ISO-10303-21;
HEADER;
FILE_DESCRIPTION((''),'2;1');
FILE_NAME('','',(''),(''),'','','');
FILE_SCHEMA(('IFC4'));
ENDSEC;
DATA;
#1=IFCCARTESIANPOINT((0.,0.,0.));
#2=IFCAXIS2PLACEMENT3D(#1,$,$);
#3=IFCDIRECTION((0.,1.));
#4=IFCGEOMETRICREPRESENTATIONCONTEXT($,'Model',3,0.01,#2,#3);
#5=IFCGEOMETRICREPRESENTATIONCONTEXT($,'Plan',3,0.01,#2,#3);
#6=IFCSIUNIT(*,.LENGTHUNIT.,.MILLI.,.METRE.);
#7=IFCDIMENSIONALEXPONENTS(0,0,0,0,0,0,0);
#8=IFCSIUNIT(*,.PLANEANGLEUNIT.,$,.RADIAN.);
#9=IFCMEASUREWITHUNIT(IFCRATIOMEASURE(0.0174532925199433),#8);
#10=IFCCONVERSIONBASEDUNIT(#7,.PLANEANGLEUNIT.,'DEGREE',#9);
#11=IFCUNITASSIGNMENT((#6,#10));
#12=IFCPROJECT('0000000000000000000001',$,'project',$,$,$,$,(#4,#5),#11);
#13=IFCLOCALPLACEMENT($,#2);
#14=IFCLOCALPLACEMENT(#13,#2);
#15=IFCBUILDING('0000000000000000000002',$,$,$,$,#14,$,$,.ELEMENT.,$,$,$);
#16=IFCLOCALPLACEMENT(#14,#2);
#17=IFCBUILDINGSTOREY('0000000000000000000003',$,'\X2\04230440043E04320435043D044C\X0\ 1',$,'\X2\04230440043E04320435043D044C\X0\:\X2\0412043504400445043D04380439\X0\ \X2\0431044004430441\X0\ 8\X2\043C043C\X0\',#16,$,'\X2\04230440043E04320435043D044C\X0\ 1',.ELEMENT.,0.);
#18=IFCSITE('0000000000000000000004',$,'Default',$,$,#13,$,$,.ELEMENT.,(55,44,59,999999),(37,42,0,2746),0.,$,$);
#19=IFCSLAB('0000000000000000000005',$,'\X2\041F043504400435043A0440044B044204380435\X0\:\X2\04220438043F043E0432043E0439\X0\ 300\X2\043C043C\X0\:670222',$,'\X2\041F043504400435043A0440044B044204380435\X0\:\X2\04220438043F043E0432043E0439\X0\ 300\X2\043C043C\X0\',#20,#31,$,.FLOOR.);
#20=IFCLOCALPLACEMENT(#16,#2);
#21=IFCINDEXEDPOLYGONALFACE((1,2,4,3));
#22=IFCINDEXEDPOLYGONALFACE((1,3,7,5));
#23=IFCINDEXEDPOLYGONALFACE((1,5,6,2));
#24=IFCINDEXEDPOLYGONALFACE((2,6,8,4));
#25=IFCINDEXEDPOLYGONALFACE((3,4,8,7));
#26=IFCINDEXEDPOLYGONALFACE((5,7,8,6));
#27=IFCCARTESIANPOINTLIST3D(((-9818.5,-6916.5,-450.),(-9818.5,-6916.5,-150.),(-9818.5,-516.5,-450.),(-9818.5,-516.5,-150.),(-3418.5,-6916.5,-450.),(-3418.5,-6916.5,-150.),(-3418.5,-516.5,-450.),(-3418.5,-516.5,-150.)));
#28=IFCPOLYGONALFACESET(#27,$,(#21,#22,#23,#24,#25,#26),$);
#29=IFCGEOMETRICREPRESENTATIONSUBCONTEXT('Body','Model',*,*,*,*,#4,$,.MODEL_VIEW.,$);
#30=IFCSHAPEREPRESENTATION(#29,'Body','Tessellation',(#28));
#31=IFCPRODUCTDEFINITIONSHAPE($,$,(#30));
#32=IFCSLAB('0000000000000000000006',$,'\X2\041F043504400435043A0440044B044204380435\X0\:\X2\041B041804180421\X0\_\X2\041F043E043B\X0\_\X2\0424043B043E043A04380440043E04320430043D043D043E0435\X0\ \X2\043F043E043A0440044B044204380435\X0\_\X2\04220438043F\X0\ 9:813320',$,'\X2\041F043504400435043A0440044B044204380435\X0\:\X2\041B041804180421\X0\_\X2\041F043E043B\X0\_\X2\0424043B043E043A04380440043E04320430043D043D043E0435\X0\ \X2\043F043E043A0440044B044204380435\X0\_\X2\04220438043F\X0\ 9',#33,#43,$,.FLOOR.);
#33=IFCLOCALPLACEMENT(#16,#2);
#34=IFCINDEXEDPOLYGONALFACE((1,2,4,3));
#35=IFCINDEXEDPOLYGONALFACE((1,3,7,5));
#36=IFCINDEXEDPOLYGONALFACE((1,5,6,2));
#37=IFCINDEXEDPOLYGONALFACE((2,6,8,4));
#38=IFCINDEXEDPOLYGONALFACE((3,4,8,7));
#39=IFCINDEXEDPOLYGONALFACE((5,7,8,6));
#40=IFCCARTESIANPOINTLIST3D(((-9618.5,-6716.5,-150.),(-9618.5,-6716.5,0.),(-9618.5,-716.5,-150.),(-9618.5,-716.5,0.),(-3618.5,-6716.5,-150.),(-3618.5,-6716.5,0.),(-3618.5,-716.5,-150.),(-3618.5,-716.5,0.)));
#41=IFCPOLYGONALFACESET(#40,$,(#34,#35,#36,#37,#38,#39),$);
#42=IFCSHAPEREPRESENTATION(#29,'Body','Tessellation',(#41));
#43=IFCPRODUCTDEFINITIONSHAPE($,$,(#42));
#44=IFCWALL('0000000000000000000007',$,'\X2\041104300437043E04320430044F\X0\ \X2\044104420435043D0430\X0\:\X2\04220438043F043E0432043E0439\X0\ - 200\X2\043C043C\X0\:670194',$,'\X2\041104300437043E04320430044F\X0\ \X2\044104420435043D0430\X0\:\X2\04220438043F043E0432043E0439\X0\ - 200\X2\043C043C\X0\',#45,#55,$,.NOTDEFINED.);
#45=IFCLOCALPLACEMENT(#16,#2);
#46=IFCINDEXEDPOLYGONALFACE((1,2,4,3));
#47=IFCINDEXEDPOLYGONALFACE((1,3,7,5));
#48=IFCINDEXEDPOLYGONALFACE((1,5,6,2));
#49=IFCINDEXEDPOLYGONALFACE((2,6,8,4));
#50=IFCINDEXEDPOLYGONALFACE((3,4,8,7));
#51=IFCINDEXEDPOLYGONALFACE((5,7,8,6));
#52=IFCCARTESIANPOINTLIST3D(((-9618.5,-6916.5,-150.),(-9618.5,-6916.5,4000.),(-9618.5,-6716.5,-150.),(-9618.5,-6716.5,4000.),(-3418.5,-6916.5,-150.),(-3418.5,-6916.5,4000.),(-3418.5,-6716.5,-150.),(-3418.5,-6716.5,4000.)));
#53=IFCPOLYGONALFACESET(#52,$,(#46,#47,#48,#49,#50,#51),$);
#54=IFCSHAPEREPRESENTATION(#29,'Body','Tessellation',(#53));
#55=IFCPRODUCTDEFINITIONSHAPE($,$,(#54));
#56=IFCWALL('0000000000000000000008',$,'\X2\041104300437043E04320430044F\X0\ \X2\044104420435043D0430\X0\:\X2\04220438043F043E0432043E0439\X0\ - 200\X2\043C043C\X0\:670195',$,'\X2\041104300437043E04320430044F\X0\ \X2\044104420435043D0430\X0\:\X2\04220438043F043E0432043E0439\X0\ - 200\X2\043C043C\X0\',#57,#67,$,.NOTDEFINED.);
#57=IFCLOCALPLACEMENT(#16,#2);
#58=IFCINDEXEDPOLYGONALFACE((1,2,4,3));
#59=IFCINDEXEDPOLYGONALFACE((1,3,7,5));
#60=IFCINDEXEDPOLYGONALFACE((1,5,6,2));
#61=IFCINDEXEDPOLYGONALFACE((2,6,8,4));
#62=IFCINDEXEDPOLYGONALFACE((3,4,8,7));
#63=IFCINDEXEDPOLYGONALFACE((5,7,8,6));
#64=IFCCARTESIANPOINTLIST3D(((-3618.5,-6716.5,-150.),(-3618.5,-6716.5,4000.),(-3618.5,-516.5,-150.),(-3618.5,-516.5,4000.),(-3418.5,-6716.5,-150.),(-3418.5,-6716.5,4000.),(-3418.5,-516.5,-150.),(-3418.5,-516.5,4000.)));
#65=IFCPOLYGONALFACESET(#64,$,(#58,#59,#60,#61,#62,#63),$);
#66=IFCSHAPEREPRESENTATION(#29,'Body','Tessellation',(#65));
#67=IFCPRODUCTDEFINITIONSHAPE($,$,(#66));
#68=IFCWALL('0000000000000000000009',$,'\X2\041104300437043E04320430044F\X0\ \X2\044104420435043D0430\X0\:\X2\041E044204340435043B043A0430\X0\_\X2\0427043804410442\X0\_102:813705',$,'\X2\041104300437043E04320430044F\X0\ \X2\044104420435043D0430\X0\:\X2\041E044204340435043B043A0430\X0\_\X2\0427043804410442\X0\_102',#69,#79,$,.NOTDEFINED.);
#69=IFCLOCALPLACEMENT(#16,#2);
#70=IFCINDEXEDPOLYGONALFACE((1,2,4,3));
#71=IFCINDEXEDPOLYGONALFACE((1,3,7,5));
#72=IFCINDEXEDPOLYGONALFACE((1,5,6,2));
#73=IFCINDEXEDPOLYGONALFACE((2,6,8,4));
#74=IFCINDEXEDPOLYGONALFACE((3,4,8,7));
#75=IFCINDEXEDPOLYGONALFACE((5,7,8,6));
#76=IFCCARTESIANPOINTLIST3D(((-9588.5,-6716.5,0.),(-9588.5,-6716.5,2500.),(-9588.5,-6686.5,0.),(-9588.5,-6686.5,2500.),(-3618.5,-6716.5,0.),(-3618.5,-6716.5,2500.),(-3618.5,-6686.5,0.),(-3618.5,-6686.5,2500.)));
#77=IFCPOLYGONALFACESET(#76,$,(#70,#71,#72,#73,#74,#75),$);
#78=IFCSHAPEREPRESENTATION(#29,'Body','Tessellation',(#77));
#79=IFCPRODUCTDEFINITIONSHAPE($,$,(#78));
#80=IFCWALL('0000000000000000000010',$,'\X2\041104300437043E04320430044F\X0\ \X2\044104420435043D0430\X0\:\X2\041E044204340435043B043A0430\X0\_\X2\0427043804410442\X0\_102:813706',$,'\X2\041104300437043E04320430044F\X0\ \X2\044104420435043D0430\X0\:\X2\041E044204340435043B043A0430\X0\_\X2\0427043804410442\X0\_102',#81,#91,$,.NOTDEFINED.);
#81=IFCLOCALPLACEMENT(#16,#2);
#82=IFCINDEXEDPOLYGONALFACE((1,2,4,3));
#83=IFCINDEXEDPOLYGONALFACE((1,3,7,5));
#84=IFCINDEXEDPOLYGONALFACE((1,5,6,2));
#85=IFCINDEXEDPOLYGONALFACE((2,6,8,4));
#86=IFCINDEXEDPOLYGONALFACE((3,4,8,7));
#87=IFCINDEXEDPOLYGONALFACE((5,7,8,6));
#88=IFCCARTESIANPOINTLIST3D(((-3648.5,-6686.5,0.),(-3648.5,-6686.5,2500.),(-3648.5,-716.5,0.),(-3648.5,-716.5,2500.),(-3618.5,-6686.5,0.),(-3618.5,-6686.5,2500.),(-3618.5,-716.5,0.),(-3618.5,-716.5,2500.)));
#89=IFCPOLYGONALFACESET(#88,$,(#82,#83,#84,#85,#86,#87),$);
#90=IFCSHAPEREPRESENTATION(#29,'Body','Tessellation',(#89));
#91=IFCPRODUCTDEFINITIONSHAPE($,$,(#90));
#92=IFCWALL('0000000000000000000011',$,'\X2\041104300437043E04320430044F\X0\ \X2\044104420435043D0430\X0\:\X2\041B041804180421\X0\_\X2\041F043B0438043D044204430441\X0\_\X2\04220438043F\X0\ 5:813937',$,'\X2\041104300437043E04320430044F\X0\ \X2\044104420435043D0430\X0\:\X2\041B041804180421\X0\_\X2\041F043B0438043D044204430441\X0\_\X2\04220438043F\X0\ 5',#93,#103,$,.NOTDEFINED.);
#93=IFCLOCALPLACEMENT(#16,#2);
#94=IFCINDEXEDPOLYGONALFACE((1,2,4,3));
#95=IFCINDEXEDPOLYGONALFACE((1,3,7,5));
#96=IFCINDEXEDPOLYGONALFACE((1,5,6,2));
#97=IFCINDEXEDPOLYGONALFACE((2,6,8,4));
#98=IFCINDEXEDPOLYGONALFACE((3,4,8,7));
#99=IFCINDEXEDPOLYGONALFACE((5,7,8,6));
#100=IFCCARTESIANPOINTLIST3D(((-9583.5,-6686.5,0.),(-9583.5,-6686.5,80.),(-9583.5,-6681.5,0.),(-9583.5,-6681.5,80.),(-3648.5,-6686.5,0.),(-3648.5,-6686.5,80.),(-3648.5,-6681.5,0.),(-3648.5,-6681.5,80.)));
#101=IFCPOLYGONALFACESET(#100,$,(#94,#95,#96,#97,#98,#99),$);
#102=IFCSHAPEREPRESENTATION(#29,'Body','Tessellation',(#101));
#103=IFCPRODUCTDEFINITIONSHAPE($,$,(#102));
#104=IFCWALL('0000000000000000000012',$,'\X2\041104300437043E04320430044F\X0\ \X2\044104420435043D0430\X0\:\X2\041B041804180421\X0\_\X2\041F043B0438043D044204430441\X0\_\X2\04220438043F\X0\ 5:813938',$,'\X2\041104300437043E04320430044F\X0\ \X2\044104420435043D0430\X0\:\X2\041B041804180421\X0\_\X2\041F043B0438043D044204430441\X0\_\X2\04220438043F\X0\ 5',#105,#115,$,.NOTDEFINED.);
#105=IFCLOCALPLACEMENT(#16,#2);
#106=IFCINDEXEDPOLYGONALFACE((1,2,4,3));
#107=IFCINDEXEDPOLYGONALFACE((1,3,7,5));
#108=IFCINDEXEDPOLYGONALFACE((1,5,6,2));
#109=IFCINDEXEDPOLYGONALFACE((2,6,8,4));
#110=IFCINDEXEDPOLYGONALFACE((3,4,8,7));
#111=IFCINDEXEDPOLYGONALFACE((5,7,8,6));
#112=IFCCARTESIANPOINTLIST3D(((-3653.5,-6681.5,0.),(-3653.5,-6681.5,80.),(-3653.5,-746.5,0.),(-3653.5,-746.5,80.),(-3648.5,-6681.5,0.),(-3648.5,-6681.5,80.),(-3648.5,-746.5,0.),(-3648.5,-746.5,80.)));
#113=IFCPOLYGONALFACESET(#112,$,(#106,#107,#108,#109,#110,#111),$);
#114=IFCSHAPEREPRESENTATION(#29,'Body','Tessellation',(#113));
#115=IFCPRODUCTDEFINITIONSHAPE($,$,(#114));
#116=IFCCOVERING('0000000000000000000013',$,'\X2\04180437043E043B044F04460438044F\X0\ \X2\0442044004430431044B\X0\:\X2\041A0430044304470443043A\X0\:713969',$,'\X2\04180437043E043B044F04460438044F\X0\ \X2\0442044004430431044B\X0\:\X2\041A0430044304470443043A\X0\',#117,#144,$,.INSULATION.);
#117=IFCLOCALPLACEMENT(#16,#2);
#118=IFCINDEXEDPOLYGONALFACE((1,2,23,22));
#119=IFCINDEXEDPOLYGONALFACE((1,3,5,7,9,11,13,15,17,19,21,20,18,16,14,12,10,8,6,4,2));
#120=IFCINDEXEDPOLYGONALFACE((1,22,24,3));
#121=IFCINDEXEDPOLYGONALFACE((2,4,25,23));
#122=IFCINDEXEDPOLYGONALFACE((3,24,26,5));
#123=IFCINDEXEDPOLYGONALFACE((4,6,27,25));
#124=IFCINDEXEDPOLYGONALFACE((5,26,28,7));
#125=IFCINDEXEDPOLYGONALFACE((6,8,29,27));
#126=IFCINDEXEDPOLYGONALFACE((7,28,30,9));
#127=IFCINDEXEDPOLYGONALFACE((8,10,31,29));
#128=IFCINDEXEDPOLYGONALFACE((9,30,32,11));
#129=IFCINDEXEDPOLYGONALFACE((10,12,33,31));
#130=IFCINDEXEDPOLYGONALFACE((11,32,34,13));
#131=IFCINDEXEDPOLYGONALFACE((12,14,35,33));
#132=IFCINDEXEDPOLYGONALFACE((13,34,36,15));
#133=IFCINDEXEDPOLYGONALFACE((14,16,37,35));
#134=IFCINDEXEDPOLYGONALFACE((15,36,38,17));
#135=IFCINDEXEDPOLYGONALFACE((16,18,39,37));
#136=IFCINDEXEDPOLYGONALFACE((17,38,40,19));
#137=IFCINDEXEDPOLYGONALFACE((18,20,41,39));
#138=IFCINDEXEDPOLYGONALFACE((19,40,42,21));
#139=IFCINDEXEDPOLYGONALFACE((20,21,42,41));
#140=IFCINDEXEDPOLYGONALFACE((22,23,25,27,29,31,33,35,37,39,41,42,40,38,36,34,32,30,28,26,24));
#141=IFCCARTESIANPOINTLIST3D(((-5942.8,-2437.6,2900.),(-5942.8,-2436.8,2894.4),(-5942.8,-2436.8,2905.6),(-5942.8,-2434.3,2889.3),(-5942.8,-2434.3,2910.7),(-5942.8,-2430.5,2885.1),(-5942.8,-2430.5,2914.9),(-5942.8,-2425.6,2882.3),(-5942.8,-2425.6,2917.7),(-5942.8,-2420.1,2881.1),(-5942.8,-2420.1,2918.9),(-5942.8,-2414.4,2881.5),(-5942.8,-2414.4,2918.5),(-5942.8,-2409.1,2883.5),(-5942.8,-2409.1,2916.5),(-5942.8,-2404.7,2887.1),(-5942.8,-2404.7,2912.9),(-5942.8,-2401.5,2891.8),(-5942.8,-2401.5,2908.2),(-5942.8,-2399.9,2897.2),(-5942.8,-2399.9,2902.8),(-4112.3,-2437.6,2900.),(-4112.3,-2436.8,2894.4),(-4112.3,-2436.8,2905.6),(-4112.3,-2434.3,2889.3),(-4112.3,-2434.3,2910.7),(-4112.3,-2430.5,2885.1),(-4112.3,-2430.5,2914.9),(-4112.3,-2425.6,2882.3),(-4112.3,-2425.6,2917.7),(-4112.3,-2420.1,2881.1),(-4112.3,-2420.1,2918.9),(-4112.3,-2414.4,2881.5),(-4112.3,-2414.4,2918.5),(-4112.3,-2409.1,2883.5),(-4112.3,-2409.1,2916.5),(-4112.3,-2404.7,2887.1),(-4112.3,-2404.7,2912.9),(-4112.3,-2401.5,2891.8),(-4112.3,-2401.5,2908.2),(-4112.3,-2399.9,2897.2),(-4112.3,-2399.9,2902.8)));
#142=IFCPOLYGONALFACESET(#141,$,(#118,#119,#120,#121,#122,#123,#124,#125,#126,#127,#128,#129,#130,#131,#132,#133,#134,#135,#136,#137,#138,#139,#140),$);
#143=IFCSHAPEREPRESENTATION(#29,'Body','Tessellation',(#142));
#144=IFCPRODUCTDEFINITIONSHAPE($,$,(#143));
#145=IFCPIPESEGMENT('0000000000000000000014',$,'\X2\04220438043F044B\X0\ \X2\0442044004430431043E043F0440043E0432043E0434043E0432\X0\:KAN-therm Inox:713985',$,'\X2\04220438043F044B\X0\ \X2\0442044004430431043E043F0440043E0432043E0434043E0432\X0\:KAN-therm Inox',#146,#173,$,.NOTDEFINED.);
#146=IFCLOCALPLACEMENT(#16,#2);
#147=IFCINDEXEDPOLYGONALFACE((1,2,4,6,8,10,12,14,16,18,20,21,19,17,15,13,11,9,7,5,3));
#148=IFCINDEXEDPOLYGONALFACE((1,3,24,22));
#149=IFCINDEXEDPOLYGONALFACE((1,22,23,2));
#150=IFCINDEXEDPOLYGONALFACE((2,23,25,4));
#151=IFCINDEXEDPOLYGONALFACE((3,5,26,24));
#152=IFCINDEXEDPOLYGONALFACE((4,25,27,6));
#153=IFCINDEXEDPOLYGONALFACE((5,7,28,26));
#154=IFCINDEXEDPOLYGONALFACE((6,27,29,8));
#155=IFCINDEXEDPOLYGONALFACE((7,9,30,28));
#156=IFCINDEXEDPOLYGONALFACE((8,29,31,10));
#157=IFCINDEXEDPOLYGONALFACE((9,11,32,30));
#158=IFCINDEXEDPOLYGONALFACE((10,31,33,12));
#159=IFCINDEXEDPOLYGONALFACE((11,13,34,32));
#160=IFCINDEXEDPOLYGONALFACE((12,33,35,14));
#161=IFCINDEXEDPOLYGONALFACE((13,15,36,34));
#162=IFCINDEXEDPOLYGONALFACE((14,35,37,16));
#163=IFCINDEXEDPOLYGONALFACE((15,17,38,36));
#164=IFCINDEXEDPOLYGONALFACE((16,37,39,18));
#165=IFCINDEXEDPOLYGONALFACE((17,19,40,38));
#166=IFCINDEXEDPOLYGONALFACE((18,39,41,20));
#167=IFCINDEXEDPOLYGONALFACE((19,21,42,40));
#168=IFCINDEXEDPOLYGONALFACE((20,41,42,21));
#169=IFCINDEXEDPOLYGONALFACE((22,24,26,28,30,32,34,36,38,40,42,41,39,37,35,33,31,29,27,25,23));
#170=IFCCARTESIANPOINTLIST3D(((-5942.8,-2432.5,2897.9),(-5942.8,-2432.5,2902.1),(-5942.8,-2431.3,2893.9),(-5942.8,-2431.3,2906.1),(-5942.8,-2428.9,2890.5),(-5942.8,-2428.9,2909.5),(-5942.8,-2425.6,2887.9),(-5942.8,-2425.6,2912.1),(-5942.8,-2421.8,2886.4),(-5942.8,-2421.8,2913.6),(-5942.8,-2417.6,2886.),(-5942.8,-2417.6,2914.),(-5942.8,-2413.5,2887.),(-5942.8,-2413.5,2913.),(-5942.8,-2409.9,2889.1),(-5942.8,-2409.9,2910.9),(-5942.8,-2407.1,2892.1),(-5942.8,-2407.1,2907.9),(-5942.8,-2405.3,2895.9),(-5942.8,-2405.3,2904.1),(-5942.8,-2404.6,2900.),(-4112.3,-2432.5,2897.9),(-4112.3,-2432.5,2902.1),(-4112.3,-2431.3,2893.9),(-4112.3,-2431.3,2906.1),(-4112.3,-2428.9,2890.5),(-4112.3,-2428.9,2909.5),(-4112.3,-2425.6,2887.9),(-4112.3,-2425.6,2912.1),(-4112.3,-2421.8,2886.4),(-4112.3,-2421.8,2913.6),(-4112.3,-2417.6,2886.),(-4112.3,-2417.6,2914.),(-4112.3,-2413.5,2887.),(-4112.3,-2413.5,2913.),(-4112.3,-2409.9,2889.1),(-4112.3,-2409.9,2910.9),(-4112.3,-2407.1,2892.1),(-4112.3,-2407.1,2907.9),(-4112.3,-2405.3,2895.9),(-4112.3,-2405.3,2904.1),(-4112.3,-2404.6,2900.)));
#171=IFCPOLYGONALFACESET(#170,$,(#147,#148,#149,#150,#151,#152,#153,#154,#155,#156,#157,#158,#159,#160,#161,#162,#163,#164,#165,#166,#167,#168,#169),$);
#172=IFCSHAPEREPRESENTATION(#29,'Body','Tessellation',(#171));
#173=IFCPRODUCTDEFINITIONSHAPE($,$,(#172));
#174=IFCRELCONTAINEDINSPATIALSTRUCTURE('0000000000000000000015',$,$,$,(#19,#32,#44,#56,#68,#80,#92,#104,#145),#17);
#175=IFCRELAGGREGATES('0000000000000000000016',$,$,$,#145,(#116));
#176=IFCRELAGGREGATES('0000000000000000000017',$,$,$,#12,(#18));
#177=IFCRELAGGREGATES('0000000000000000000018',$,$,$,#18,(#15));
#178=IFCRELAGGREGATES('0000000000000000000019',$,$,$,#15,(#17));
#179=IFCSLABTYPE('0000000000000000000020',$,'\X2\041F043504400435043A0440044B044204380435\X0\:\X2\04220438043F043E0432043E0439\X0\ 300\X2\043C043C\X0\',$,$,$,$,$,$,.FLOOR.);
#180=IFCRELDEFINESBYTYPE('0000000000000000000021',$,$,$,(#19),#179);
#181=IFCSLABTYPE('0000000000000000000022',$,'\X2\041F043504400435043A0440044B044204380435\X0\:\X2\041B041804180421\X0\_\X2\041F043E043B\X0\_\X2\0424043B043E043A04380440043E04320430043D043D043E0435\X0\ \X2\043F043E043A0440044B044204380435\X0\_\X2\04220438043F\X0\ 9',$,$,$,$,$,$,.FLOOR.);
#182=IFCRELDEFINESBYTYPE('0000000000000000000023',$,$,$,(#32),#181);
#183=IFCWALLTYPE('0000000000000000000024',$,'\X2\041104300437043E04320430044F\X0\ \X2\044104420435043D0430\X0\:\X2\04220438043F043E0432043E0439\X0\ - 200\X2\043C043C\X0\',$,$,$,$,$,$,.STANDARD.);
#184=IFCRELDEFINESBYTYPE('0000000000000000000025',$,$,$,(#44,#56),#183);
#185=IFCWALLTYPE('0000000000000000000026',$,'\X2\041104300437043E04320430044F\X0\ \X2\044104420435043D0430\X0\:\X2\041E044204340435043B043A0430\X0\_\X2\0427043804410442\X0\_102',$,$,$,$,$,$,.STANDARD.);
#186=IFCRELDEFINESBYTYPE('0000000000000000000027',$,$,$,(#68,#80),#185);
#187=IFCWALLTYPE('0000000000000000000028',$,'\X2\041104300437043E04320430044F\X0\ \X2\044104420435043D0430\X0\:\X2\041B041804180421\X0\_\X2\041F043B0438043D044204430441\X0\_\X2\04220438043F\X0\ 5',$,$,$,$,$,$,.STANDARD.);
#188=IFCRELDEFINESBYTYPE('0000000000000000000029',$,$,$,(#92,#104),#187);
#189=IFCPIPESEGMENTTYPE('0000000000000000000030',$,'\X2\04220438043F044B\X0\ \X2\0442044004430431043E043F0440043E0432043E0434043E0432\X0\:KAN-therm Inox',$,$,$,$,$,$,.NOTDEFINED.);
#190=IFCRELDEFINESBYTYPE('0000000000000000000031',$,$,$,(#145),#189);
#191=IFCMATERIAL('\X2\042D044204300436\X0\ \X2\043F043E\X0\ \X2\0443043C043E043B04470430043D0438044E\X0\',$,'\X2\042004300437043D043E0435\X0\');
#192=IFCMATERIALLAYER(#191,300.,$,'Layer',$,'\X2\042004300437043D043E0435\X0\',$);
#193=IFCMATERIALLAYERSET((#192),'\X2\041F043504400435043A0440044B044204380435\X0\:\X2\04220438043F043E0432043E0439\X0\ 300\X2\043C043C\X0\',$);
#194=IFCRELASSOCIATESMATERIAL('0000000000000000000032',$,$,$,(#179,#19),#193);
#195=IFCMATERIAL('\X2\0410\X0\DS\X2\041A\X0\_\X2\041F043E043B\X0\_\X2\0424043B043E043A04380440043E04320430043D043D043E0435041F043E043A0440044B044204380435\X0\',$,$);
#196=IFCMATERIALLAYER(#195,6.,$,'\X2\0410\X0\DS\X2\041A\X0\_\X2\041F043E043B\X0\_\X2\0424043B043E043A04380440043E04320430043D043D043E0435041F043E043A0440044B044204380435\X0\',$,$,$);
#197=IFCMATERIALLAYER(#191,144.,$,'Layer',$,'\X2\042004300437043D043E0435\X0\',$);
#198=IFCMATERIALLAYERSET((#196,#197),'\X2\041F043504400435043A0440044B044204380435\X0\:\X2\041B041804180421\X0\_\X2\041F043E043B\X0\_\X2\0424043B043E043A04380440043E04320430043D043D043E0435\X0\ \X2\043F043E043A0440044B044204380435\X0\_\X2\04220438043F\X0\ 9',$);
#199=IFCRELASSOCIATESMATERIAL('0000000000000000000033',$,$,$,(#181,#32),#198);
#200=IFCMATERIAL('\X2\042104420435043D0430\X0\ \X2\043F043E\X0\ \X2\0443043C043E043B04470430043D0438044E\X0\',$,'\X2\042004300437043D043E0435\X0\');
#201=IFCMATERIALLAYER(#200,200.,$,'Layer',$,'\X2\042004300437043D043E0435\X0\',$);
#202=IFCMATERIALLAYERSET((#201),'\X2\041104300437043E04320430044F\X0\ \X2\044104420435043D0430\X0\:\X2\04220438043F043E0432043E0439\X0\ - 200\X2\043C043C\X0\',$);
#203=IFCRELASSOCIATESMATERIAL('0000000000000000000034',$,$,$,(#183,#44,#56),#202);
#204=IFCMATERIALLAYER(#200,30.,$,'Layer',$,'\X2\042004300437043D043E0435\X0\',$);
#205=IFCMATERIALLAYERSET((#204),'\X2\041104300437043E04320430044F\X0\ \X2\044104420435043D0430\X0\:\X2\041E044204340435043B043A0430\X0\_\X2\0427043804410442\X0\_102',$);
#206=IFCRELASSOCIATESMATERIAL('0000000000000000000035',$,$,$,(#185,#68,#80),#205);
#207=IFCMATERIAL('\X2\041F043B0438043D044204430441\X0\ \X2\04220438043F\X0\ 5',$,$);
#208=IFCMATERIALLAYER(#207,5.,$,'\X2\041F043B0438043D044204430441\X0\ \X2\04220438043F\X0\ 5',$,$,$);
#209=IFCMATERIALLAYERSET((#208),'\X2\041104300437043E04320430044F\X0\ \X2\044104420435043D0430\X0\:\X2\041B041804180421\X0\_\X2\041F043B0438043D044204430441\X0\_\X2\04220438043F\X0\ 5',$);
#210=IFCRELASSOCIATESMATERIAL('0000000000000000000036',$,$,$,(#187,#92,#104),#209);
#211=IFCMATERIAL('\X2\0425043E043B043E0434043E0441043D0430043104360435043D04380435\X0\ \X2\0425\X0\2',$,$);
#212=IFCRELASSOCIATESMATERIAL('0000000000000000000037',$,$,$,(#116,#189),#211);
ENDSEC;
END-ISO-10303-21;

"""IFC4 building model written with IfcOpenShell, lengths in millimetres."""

from ifc_helpers import new_model, entity, si_unit, converted_unit, direction, frame, frame_2d, origin, origin_2d_with_axis, place, context, subcontext, project, spatial, rectangle, circle, extrude, material, layer, layer_set, layer_usage, type_object, element, aggregate, save


model = new_model("IFC4")

# Units and contexts
model_context = context("Model", 3, precision=0.01, world=origin(), true_north=direction((0.0, 1.0)))
plan_context = context("Plan", 3, precision=0.01, world=origin(), true_north=direction((0.0, 1.0)))
body_context = subcontext(model_context, "Body", "Model", "MODEL_VIEW")
ifc_project = project(units=[si_unit("LENGTHUNIT", "METRE", prefix="MILLI"), converted_unit("PLANEANGLEUNIT", "DEGREE", entity("IfcRatioMeasure", 0.0174532925199433), si_unit("PLANEANGLEUNIT", "RADIAN"), dimensions=[0, 0, 0, 0, 0, 0, 0])], contexts=[model_context, plan_context])

# Site, building, storey
site_placement = place(None, origin())
site = spatial("IfcSite", under=ifc_project, at=site_placement, Name="Default", CompositionType="ELEMENT", RefLatitude=(55, 44, 59, 999999), RefLongitude=(37, 42, 0, 2746), RefElevation=0.0)
building_placement = place(site_placement, origin())
building = spatial("IfcBuilding", under=site, at=building_placement, CompositionType="ELEMENT")
storey_placement = place(building_placement, origin())
storey = spatial("IfcBuildingStorey", under=building, at=storey_placement, Name="Уровень 1", ObjectType="Уровень:Верхний брус 8мм", LongName="Уровень 1", CompositionType="ELEMENT", Elevation=0.0)

# Slabs
ifc_material_1 = material(Name="Этаж по умолчанию", Category="Разное")
ifc_layer_1 = layer(ifc_material_1, 300.0, Name="Layer", Category="Разное")
ifc_layer_set_1 = layer_set([ifc_layer_1], Name="Перекрытие:Типовой 300мм")
ifc_layer_usage_1 = layer_usage(ifc_layer_set_1, "AXIS3", "POSITIVE", 0.0)
slab_type_1 = type_object("IfcSlabType", Name="Перекрытие:Типовой 300мм", PredefinedType="FLOOR", material=ifc_layer_set_1)
slab_1_placement = place(storey_placement, origin())
element("IfcSlab", 1, at=slab_1_placement, inside=storey, type_object=slab_type_1, material=ifc_layer_usage_1, Name="Перекрытие:Типовой 300мм:670222", ObjectType="Перекрытие:Типовой 300мм", PredefinedType="FLOOR", context=body_context, shape_type="SweptSolid", body=[
    extrude(rectangle(XDim=6400.0, YDim=6400.0, at=origin_2d_with_axis()), frame((-6618.5, -3716.5, -150.0), z_axis=(0.0, 0.0, -1.0), x_axis=(0.0, 1.0, 0.0)), (0.0, 0.0, 1.0), 300.0),
])
ifc_material_2 = material(Name="АDSК_Пол_ФлокированноеПокрытие")
ifc_layer_2 = layer(ifc_material_2, 6.0, Name="АDSК_Пол_ФлокированноеПокрытие")
ifc_layer_3 = layer(ifc_material_1, 144.0, Name="Layer", Category="Разное")
ifc_layer_set_2 = layer_set([ifc_layer_2, ifc_layer_3], Name="Перекрытие:ЛИИС_Пол_Флокированное покрытие_Тип 9")
ifc_layer_usage_2 = layer_usage(ifc_layer_set_2, "AXIS3", "POSITIVE", 0.0)
slab_type_2 = type_object("IfcSlabType", Name="Перекрытие:ЛИИС_Пол_Флокированное покрытие_Тип 9", PredefinedType="FLOOR", material=ifc_layer_set_2)
slab_2_placement = place(storey_placement, origin())
element("IfcSlab", 2, at=slab_2_placement, inside=storey, type_object=slab_type_2, material=ifc_layer_usage_2, Name="Перекрытие:ЛИИС_Пол_Флокированное покрытие_Тип 9:813320", ObjectType="Перекрытие:ЛИИС_Пол_Флокированное покрытие_Тип 9", PredefinedType="FLOOR", context=body_context, shape_type="SweptSolid", body=[
    extrude(rectangle(XDim=6000.0, YDim=6000.0, at=origin_2d_with_axis()), frame((-6618.5, -3716.5, 0.0), z_axis=(0.0, 0.0, -1.0), x_axis=(0.0, 1.0, 0.0)), (0.0, 0.0, 1.0), 150.0),
])

# Walls
ifc_material_3 = material(Name="Стена по умолчанию", Category="Разное")
ifc_layer_4 = layer(ifc_material_3, 200.0, Name="Layer", Category="Разное")
ifc_layer_set_3 = layer_set([ifc_layer_4], Name="Базовая стена:Типовой - 200мм")
ifc_layer_usage_3 = layer_usage(ifc_layer_set_3, "AXIS2", "NEGATIVE", 100.0)
wall_type_1 = type_object("IfcWallType", Name="Базовая стена:Типовой - 200мм", PredefinedType="STANDARD", material=ifc_layer_set_3)
wall_1_placement = place(storey_placement, frame((-3418.5, -6816.5, -150.0), z_axis=(0.0, 0.0, 1.0), x_axis=(-1.0, 0.0, 0.0)))
element("IfcWall", 3, at=wall_1_placement, inside=storey, type_object=wall_type_1, material=ifc_layer_usage_3, Name="Базовая стена:Типовой - 200мм:670194", ObjectType="Базовая стена:Типовой - 200мм", PredefinedType="NOTDEFINED", context=body_context, shape_type="SweptSolid", body=[
    extrude(rectangle(XDim=6200.0, YDim=200.0, at=frame_2d((3100.0, 0.0), x_axis=(-1.0, 0.0))), origin(), (0.0, 0.0, 1.0), 4150.0),
])
ifc_layer_usage_4 = layer_usage(ifc_layer_set_3, "AXIS2", "NEGATIVE", 100.0)
wall_2_placement = place(storey_placement, frame((-3518.5, -516.5, -150.0), z_axis=(0.0, 0.0, 1.0), x_axis=(0.0, -1.0, 0.0)))
element("IfcWall", 4, at=wall_2_placement, inside=storey, type_object=wall_type_1, material=ifc_layer_usage_4, Name="Базовая стена:Типовой - 200мм:670195", ObjectType="Базовая стена:Типовой - 200мм", PredefinedType="NOTDEFINED", context=body_context, shape_type="SweptSolid", body=[
    extrude(rectangle(XDim=6200.0, YDim=200.0, at=frame_2d((3100.0, 0.0), x_axis=(-1.0, 0.0))), origin(), (0.0, 0.0, 1.0), 4150.0),
])
ifc_layer_5 = layer(ifc_material_3, 30.0, Name="Layer", Category="Разное")
ifc_layer_set_4 = layer_set([ifc_layer_5], Name="Базовая стена:Отделка_Чист_102")
ifc_layer_usage_5 = layer_usage(ifc_layer_set_4, "AXIS2", "POSITIVE", -15.0)
wall_type_2 = type_object("IfcWallType", Name="Базовая стена:Отделка_Чист_102", PredefinedType="STANDARD", material=ifc_layer_set_4)
wall_3_placement = place(storey_placement, frame((-3618.5, -6701.5, 0.0), z_axis=(0.0, 0.0, 1.0), x_axis=(-1.0, 0.0, 0.0)))
element("IfcWall", 5, at=wall_3_placement, inside=storey, type_object=wall_type_2, material=ifc_layer_usage_5, Name="Базовая стена:Отделка_Чист_102:813705", ObjectType="Базовая стена:Отделка_Чист_102", PredefinedType="NOTDEFINED", context=body_context, shape_type="SweptSolid", body=[
    extrude(rectangle(XDim=5970.0, YDim=30.0, at=frame_2d((2985.0, 0.0), x_axis=(-1.0, 0.0))), origin(), (0.0, 0.0, 1.0), 2500.0),
])
ifc_layer_usage_6 = layer_usage(ifc_layer_set_4, "AXIS2", "POSITIVE", -15.0)
wall_4_placement = place(storey_placement, frame((-3633.5, -716.5, 0.0), z_axis=(0.0, 0.0, 1.0), x_axis=(0.0, -1.0, 0.0)))
element("IfcWall", 6, at=wall_4_placement, inside=storey, type_object=wall_type_2, material=ifc_layer_usage_6, Name="Базовая стена:Отделка_Чист_102:813706", ObjectType="Базовая стена:Отделка_Чист_102", PredefinedType="NOTDEFINED", context=body_context, shape_type="SweptSolid", body=[
    extrude(rectangle(XDim=5970.0, YDim=30.0, at=frame_2d((2985.0, 0.0), x_axis=(-1.0, 0.0))), origin(), (0.0, 0.0, 1.0), 2500.0),
])
ifc_material_4 = material(Name="Плинтус Тип 5")
ifc_layer_6 = layer(ifc_material_4, 5.0, Name="Плинтус Тип 5")
ifc_layer_set_5 = layer_set([ifc_layer_6], Name="Базовая стена:ЛИИС_Плинтус_Тип 5")
ifc_layer_usage_7 = layer_usage(ifc_layer_set_5, "AXIS2", "NEGATIVE", 2.5)
wall_type_3 = type_object("IfcWallType", Name="Базовая стена:ЛИИС_Плинтус_Тип 5", PredefinedType="STANDARD", material=ifc_layer_set_5)
wall_5_placement = place(storey_placement, frame((-3648.5, -6684.0, 0.0), z_axis=(0.0, 0.0, 1.0), x_axis=(-1.0, 0.0, 0.0)))
element("IfcWall", 7, at=wall_5_placement, inside=storey, type_object=wall_type_3, material=ifc_layer_usage_7, Name="Базовая стена:ЛИИС_Плинтус_Тип 5:813937", ObjectType="Базовая стена:ЛИИС_Плинтус_Тип 5", PredefinedType="NOTDEFINED", context=body_context, shape_type="SweptSolid", body=[
    extrude(rectangle(XDim=5935.0, YDim=5.0, at=frame_2d((2967.5, 0.0), x_axis=(-1.0, 0.0))), origin(), (0.0, 0.0, 1.0), 80.0),
])
ifc_layer_usage_8 = layer_usage(ifc_layer_set_5, "AXIS2", "NEGATIVE", 2.5)
wall_6_placement = place(storey_placement, frame((-3651.0, -746.5, 0.0), z_axis=(0.0, 0.0, 1.0), x_axis=(0.0, -1.0, 0.0)))
element("IfcWall", 8, at=wall_6_placement, inside=storey, type_object=wall_type_3, material=ifc_layer_usage_8, Name="Базовая стена:ЛИИС_Плинтус_Тип 5:813938", ObjectType="Базовая стена:ЛИИС_Плинтус_Тип 5", PredefinedType="NOTDEFINED", context=body_context, shape_type="SweptSolid", body=[
    extrude(rectangle(XDim=5935.0, YDim=5.0, at=frame_2d((2967.5, 0.0), x_axis=(-1.0, 0.0))), origin(), (0.0, 0.0, 1.0), 80.0),
])

# Covering
ifc_material_5 = material(Name="Холодоснабжение Х2")
covering_1_placement = place(storey_placement, frame((-5942.8, -2439.2, 2879.4)))
covering_1 = element("IfcCovering", 9, at=covering_1_placement, material=ifc_material_5, Name="Изоляция трубы:Каучук:713969", ObjectType="Изоляция трубы:Каучук", PredefinedType="INSULATION", context=body_context, shape_type="SweptSolid", body=[
    extrude(circle(Radius=19.0, at=frame_2d((0.0, 0.0), x_axis=(1.0, 0.0))), frame((0.0, 20.6, 20.6), z_axis=(1.0, 0.0, 0.0), x_axis=(0.0, -1.0, 0.0)), (0.0, 0.0, 1.0), 1830.4),
])

# Pipe segment
pipe_segment_type_1 = type_object("IfcPipeSegmentType", Name="Типы трубопроводов:KAN-therm Inox", PredefinedType="NOTDEFINED", material=ifc_material_5)
pipe_segment_1_placement = place(storey_placement, frame((-5942.8, -2434.2, 2884.4)))
pipe_segment_1 = element("IfcPipeSegment", 10, at=pipe_segment_1_placement, inside=storey, type_object=pipe_segment_type_1, Name="Типы трубопроводов:KAN-therm Inox:713985", ObjectType="Типы трубопроводов:KAN-therm Inox", PredefinedType="NOTDEFINED", context=body_context, shape_type="SweptSolid", body=[
    extrude(circle(Radius=14.0, at=frame_2d((0.0, 0.0), x_axis=(1.0, 0.0))), frame((0.0, 15.6, 15.6), z_axis=(1.0, 0.0, 0.0), x_axis=(0.0, 1.0, 0.0)), (0.0, 0.0, 1.0), 1830.4),
])
aggregate(pipe_segment_1, [covering_1])

save(model, "model.ifc")
